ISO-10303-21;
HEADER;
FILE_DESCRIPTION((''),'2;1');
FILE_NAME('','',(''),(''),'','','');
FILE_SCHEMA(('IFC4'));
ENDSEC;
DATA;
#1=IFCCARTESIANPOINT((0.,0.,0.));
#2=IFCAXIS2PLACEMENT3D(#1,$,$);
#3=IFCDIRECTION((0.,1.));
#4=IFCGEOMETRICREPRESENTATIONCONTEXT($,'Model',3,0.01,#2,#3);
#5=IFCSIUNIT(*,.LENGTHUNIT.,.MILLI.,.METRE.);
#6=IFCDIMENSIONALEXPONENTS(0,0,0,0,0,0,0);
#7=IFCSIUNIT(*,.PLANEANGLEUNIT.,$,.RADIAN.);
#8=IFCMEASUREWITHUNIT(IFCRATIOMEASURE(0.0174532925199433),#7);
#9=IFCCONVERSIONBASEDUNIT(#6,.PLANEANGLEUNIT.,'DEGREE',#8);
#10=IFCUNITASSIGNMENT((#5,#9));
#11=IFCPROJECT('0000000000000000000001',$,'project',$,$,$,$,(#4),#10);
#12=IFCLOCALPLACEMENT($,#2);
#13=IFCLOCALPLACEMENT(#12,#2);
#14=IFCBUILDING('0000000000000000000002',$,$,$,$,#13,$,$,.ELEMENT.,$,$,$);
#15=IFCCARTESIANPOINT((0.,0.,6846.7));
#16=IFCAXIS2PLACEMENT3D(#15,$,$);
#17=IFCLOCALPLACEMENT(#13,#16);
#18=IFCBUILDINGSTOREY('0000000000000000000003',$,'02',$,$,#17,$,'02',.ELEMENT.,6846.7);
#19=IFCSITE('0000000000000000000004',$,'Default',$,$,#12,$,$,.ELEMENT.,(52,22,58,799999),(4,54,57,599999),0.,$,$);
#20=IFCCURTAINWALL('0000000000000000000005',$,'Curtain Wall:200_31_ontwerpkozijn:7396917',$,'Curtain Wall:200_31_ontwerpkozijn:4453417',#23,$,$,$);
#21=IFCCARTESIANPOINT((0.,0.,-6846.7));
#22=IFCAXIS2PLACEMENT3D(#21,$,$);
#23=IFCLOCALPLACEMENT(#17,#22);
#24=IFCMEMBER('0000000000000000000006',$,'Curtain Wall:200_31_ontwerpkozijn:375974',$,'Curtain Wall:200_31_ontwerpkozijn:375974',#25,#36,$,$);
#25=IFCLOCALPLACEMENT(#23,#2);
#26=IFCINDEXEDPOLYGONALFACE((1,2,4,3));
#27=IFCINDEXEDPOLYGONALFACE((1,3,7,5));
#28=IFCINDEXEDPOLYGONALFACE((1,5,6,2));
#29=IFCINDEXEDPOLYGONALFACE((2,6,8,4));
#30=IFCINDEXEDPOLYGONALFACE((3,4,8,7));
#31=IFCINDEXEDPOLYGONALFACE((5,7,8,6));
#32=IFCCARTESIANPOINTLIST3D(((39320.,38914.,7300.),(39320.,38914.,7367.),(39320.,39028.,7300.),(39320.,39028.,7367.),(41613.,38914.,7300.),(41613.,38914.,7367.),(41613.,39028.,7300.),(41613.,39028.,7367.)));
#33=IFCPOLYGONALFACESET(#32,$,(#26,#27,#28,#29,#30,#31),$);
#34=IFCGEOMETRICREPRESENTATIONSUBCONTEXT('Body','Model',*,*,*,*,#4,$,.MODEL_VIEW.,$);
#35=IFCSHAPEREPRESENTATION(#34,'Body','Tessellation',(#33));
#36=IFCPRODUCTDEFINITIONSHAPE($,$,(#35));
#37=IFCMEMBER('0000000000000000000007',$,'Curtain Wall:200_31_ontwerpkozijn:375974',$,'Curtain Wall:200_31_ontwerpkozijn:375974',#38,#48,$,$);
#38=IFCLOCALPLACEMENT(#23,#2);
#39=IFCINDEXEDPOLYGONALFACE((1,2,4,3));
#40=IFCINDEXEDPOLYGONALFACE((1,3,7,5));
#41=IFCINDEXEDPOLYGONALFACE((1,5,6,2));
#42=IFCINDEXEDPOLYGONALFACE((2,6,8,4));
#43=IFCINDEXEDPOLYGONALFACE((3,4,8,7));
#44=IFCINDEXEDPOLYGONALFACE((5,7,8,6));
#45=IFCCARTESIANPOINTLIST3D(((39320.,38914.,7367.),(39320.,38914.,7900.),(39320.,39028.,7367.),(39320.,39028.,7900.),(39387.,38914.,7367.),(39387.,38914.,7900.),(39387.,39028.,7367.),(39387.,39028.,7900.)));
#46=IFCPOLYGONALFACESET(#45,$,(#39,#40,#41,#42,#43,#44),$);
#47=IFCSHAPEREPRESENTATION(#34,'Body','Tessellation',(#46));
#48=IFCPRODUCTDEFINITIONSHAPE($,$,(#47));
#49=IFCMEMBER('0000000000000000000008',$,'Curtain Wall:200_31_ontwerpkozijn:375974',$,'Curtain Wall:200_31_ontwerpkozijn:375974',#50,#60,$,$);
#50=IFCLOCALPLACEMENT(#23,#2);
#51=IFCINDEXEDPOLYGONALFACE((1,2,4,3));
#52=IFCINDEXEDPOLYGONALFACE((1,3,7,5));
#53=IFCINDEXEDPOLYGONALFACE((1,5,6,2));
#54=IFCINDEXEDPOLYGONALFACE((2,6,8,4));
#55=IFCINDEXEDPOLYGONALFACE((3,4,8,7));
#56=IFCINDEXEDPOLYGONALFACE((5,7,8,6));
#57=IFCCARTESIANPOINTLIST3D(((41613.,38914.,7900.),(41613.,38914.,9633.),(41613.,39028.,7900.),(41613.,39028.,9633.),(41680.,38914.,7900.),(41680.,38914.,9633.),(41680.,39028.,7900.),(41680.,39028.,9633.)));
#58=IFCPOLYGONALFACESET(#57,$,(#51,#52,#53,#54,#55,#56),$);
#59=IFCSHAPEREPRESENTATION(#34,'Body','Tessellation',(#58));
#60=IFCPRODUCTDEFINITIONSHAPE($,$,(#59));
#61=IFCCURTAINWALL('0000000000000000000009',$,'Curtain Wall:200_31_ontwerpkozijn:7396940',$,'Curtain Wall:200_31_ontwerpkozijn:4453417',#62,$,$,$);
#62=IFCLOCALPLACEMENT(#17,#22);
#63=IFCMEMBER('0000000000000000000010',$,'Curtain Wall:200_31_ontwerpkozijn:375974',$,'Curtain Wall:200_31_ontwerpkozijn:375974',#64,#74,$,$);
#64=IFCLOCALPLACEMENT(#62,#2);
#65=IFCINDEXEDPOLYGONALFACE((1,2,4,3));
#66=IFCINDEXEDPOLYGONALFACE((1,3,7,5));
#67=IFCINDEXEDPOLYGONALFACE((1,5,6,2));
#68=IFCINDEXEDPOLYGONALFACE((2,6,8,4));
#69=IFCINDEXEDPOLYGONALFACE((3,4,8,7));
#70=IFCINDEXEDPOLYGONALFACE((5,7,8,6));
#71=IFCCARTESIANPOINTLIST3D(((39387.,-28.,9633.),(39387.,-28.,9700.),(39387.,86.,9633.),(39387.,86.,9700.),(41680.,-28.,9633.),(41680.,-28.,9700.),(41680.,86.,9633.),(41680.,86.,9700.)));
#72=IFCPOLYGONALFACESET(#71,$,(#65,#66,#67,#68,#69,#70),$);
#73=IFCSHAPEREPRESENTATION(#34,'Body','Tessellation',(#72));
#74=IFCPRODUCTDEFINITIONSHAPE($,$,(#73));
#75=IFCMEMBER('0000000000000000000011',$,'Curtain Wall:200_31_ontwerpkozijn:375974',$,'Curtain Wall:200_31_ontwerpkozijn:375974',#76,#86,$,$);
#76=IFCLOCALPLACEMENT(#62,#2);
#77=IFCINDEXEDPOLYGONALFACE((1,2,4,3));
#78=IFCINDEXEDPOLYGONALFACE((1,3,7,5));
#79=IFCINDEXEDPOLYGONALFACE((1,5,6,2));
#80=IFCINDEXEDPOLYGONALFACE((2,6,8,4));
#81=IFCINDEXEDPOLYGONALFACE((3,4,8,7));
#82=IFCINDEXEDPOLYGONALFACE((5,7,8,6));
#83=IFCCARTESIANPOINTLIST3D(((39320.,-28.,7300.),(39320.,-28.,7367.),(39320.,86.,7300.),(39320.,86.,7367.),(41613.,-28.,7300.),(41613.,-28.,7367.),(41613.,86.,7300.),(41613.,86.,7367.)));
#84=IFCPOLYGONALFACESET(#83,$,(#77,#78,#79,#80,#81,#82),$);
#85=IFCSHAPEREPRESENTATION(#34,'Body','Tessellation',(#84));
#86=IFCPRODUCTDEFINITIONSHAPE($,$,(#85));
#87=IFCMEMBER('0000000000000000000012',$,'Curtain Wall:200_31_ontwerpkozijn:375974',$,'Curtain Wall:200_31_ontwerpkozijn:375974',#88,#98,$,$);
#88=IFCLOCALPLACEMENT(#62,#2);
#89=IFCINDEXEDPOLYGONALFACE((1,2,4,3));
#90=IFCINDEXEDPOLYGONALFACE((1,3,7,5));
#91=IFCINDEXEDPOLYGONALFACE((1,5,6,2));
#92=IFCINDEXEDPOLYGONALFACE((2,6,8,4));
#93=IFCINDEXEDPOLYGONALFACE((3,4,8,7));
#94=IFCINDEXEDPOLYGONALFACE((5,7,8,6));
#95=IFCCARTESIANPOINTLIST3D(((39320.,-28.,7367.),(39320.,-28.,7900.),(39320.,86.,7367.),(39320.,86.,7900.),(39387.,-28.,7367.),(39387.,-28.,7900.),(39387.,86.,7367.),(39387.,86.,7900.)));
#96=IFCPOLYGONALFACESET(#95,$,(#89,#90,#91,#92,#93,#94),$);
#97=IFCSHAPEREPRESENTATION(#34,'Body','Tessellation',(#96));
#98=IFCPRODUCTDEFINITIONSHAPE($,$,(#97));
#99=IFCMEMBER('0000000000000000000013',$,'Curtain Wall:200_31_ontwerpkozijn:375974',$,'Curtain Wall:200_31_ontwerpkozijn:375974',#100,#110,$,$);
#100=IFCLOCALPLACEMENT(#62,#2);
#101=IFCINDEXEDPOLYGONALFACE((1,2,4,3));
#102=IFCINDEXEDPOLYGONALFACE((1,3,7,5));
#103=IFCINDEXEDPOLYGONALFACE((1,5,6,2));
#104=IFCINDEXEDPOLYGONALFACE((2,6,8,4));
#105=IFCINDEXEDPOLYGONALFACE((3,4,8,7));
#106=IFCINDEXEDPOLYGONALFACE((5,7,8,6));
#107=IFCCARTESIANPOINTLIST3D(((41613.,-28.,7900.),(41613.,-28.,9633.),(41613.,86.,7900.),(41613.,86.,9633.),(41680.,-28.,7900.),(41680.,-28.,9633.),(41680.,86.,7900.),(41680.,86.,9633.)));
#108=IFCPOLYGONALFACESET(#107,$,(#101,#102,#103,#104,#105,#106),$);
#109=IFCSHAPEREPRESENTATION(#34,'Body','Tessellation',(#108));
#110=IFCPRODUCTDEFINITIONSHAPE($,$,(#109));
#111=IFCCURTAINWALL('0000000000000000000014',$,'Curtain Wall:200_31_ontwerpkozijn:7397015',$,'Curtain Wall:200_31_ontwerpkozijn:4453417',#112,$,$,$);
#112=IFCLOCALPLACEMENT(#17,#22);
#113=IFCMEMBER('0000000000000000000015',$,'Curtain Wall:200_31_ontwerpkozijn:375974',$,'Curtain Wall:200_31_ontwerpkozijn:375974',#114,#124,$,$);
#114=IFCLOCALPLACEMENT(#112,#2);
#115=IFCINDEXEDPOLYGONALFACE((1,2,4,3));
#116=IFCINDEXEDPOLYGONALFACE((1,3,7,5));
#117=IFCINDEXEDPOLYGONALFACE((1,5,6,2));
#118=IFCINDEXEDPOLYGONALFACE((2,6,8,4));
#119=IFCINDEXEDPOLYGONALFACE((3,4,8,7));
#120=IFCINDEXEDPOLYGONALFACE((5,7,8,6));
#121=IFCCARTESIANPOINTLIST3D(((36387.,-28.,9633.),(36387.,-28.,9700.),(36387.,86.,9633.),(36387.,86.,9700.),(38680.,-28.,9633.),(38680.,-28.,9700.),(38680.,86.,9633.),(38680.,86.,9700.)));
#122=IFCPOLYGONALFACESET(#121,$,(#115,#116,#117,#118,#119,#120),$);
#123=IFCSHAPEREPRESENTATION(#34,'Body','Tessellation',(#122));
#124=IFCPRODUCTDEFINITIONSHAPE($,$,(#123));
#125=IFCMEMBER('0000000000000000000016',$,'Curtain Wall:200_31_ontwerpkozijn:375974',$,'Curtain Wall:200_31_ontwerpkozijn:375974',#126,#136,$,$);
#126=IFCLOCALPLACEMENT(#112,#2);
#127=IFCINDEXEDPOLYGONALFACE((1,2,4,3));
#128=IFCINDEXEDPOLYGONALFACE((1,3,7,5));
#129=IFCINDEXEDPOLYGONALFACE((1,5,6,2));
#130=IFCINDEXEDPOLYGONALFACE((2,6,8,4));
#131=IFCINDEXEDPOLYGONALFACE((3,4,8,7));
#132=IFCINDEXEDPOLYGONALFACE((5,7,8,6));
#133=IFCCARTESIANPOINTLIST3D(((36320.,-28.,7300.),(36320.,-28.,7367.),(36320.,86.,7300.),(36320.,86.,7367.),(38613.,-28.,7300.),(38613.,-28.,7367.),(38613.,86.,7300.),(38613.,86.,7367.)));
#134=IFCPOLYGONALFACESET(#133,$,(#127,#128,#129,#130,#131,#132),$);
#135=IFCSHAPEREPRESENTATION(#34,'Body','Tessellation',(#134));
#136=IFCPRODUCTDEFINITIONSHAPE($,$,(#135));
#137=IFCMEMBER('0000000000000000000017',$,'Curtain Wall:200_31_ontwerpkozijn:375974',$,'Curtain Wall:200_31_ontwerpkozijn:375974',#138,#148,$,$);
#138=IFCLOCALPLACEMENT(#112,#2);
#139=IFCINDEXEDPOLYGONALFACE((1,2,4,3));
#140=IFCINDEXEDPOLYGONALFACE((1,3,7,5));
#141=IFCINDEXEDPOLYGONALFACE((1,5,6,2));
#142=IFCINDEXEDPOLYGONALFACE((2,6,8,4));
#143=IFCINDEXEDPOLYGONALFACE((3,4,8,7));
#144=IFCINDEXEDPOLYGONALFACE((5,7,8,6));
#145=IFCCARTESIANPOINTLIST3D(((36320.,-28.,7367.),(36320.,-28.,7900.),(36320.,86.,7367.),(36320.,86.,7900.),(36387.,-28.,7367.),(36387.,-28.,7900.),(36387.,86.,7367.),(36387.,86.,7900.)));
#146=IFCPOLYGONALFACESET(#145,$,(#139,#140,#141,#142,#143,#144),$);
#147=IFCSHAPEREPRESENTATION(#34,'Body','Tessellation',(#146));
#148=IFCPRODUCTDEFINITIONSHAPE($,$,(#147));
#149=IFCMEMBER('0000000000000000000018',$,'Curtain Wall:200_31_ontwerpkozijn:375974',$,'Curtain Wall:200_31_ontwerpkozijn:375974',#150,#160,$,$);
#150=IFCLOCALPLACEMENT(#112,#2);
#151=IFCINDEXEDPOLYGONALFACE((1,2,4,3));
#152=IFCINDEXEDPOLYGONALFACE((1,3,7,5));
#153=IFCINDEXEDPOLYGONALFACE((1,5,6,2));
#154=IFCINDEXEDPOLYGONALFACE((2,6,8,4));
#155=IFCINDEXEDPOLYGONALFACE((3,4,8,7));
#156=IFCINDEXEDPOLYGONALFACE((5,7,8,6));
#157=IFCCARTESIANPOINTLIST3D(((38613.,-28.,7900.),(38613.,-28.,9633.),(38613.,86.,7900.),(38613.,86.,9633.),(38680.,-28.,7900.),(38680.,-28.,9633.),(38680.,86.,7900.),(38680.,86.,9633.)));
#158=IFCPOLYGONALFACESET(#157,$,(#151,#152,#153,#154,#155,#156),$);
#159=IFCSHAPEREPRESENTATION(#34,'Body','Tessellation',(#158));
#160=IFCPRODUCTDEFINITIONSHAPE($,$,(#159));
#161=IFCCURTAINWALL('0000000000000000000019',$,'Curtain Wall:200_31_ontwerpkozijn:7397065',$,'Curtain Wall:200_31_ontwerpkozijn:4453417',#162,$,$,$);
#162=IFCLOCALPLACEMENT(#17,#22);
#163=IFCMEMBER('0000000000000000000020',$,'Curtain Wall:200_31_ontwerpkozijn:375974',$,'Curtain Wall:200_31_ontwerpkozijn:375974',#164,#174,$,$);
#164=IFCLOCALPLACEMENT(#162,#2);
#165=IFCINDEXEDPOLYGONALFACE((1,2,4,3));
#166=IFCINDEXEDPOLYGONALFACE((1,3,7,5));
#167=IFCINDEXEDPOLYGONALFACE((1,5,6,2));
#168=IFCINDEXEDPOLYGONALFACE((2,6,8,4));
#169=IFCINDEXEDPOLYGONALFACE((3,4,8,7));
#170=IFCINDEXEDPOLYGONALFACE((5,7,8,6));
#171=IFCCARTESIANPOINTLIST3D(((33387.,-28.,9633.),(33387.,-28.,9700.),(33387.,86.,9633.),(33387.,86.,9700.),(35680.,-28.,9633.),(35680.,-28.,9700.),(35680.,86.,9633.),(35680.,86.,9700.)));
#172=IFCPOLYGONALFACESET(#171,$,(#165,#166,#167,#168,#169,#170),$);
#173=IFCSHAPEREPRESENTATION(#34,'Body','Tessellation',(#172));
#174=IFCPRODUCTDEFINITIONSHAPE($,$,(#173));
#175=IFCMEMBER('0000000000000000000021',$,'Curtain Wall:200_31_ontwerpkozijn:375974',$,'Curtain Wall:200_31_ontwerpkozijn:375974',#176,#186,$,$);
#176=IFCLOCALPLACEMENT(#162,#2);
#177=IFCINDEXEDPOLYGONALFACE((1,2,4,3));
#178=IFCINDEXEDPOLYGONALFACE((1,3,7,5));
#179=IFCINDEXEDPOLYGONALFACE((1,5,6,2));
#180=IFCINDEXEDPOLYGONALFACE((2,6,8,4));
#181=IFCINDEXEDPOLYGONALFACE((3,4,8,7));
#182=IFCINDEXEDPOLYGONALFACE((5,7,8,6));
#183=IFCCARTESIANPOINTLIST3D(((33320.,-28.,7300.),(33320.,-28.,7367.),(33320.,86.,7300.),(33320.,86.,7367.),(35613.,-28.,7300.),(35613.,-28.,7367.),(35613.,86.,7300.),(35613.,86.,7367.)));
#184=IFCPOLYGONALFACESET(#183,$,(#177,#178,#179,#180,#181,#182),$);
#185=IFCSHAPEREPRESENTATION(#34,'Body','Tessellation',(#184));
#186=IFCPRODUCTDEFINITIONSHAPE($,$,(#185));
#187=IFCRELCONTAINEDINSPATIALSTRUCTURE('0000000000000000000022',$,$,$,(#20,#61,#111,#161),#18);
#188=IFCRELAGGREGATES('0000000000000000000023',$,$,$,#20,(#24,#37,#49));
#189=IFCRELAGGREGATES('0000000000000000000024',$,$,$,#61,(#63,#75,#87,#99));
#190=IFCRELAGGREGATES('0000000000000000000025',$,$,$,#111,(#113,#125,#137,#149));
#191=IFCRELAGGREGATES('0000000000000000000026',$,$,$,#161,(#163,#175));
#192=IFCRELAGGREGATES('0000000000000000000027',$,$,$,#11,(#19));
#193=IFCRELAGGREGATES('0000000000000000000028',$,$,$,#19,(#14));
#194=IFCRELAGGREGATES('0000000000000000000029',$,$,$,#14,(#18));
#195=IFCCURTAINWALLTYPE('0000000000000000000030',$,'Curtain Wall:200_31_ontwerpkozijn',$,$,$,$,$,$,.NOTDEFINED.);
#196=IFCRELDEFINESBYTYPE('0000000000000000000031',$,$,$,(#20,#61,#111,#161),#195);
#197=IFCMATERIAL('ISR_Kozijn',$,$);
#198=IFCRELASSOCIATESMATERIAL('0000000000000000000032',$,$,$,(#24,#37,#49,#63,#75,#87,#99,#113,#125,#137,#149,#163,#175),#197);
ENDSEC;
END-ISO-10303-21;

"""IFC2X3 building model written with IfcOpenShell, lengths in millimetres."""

from ifc_helpers import new_model, entity, si_unit, converted_unit, direction, frame, frame_2d, origin, origin_2d_with_axis, place, context, subcontext, project, spatial, rectangle, extrude, material, type_object, element, aggregate, save


model = new_model("IFC2X3")

# Units and contexts
model_context = context("Model", 3, precision=0.01, world=origin(), true_north=direction((0.0, 1.0)))
body_context = subcontext(model_context, "Body", "Model", "MODEL_VIEW")
ifc_project = project(units=[si_unit("LENGTHUNIT", "METRE", prefix="MILLI"), converted_unit("PLANEANGLEUNIT", "DEGREE", entity("IfcRatioMeasure", 0.0174532925199433), si_unit("PLANEANGLEUNIT", "RADIAN"), dimensions=[0, 0, 0, 0, 0, 0, 0])], contexts=[model_context])

# Site, building, storey
site_placement = place(None, origin())
site = spatial("IfcSite", under=ifc_project, at=site_placement, Name="Default", CompositionType="ELEMENT", RefLatitude=(52, 22, 58, 799999), RefLongitude=(4, 54, 57, 599999), RefElevation=0.0)
building_placement = place(site_placement, origin())
building = spatial("IfcBuilding", under=site, at=building_placement, CompositionType="ELEMENT")
storey_placement = place(building_placement, frame((0.0, 0.0, 6846.7)))
storey = spatial("IfcBuildingStorey", under=building, at=storey_placement, Name="02", LongName="02", CompositionType="ELEMENT", Elevation=6846.7)

# Curtain walls, members
curtain_wall_type = type_object("IfcCurtainWallType", Name="Curtain Wall:200_31_ontwerpkozijn", PredefinedType="NOTDEFINED")
ifc_material = material(Name="ISR_Kozijn")
curtain_wall_1_placement = place(storey_placement, frame((0.0, 0.0, -6846.7)))
curtain_wall_1 = element("IfcCurtainWall", 1, at=curtain_wall_1_placement, inside=storey, type_object=curtain_wall_type, Name="Curtain Wall:200_31_ontwerpkozijn:7396917", ObjectType="Curtain Wall:200_31_ontwerpkozijn:4453417")
member_1_placement = place(curtain_wall_1_placement, origin())
member_1 = element("IfcMember", 2, at=member_1_placement, material=ifc_material, Name="Curtain Wall:200_31_ontwerpkozijn:375974", ObjectType="Curtain Wall:200_31_ontwerpkozijn:375974", context=body_context, shape_type="SweptSolid", body=[
    extrude(rectangle(XDim=67.0, YDim=114.0, at=frame_2d((0.0, 0.0), x_axis=(1.0, 0.0))), frame((41613.0, 38971.0, 7333.5), z_axis=(-1.0, 0.0, 0.0), x_axis=(0.0, 0.0, -1.0)), (0.0, 0.0, 1.0), 2293.0),
])
member_2_placement = place(curtain_wall_1_placement, origin())
member_2 = element("IfcMember", 3, at=member_2_placement, material=ifc_material, Name="Curtain Wall:200_31_ontwerpkozijn:375974", ObjectType="Curtain Wall:200_31_ontwerpkozijn:375974", context=body_context, shape_type="SweptSolid", body=[
    extrude(rectangle(XDim=67.0, YDim=114.0, at=frame_2d((0.0, 0.0), x_axis=(1.0, 0.0))), frame((39353.5, 38971.0, 7367.0), z_axis=(0.0, 0.0, 1.0), x_axis=(-1.0, 0.0, 0.0)), (0.0, 0.0, 1.0), 533.0),
])
member_3_placement = place(curtain_wall_1_placement, origin())
member_3 = element("IfcMember", 4, at=member_3_placement, material=ifc_material, Name="Curtain Wall:200_31_ontwerpkozijn:375974", ObjectType="Curtain Wall:200_31_ontwerpkozijn:375974", context=body_context, shape_type="SweptSolid", body=[
    extrude(rectangle(XDim=67.0, YDim=114.0, at=frame_2d((0.0, 0.0), x_axis=(1.0, 0.0))), frame((41646.5, 38971.0, 9633.0), z_axis=(0.0, 0.0, -1.0), x_axis=(-1.0, 0.0, 0.0)), (0.0, 0.0, 1.0), 1733.0),
])
aggregate(curtain_wall_1, [member_1, member_2, member_3])
curtain_wall_2_placement = place(storey_placement, frame((0.0, 0.0, -6846.7)))
curtain_wall_2 = element("IfcCurtainWall", 5, at=curtain_wall_2_placement, inside=storey, type_object=curtain_wall_type, Name="Curtain Wall:200_31_ontwerpkozijn:7396940", ObjectType="Curtain Wall:200_31_ontwerpkozijn:4453417")
member_4_placement = place(curtain_wall_2_placement, origin())
member_4 = element("IfcMember", 6, at=member_4_placement, material=ifc_material, Name="Curtain Wall:200_31_ontwerpkozijn:375974", ObjectType="Curtain Wall:200_31_ontwerpkozijn:375974", context=body_context, shape_type="SweptSolid", body=[
    extrude(rectangle(XDim=67.0, YDim=114.0, at=frame_2d((0.0, 0.0), x_axis=(1.0, 0.0))), frame((39387.0, 29.0, 9666.5), z_axis=(1.0, 0.0, 0.0), x_axis=(0.0, 0.0, -1.0)), (0.0, 0.0, 1.0), 2293.0),
])
member_5_placement = place(curtain_wall_2_placement, origin())
member_5 = element("IfcMember", 7, at=member_5_placement, material=ifc_material, Name="Curtain Wall:200_31_ontwerpkozijn:375974", ObjectType="Curtain Wall:200_31_ontwerpkozijn:375974", context=body_context, shape_type="SweptSolid", body=[
    extrude(rectangle(XDim=67.0, YDim=114.0, at=frame_2d((0.0, 0.0), x_axis=(1.0, 0.0))), frame((41613.0, 29.0, 7333.5), z_axis=(-1.0, 0.0, 0.0), x_axis=(0.0, 0.0, -1.0)), (0.0, 0.0, 1.0), 2293.0),
])
member_6_placement = place(curtain_wall_2_placement, origin())
member_6 = element("IfcMember", 8, at=member_6_placement, material=ifc_material, Name="Curtain Wall:200_31_ontwerpkozijn:375974", ObjectType="Curtain Wall:200_31_ontwerpkozijn:375974", context=body_context, shape_type="SweptSolid", body=[
    extrude(rectangle(XDim=67.0, YDim=114.0, at=origin_2d_with_axis()), frame((39353.5, 29.0, 7367.0), z_axis=(0.0, 0.0, 1.0), x_axis=(-1.0, 0.0, 0.0)), (0.0, 0.0, 1.0), 533.0),
])
member_7_placement = place(curtain_wall_2_placement, origin())
member_7 = element("IfcMember", 9, at=member_7_placement, material=ifc_material, Name="Curtain Wall:200_31_ontwerpkozijn:375974", ObjectType="Curtain Wall:200_31_ontwerpkozijn:375974", context=body_context, shape_type="SweptSolid", body=[
    extrude(rectangle(XDim=67.0, YDim=114.0, at=origin_2d_with_axis()), frame((41646.5, 29.0, 9633.0), z_axis=(0.0, 0.0, -1.0), x_axis=(-1.0, 0.0, 0.0)), (0.0, 0.0, 1.0), 1733.0),
])
aggregate(curtain_wall_2, [member_4, member_5, member_6, member_7])
curtain_wall_3_placement = place(storey_placement, frame((0.0, 0.0, -6846.7)))
curtain_wall_3 = element("IfcCurtainWall", 10, at=curtain_wall_3_placement, inside=storey, type_object=curtain_wall_type, Name="Curtain Wall:200_31_ontwerpkozijn:7397015", ObjectType="Curtain Wall:200_31_ontwerpkozijn:4453417")
member_8_placement = place(curtain_wall_3_placement, origin())
member_8 = element("IfcMember", 11, at=member_8_placement, material=ifc_material, Name="Curtain Wall:200_31_ontwerpkozijn:375974", ObjectType="Curtain Wall:200_31_ontwerpkozijn:375974", context=body_context, shape_type="SweptSolid", body=[
    extrude(rectangle(XDim=67.0, YDim=114.0, at=frame_2d((0.0, 0.0), x_axis=(1.0, 0.0))), frame((36387.0, 29.0, 9666.5), z_axis=(1.0, 0.0, 0.0), x_axis=(0.0, 0.0, -1.0)), (0.0, 0.0, 1.0), 2293.0),
])
member_9_placement = place(curtain_wall_3_placement, origin())
member_9 = element("IfcMember", 12, at=member_9_placement, material=ifc_material, Name="Curtain Wall:200_31_ontwerpkozijn:375974", ObjectType="Curtain Wall:200_31_ontwerpkozijn:375974", context=body_context, shape_type="SweptSolid", body=[
    extrude(rectangle(XDim=67.0, YDim=114.0, at=frame_2d((0.0, 0.0), x_axis=(1.0, 0.0))), frame((38613.0, 29.0, 7333.5), z_axis=(-1.0, 0.0, 0.0), x_axis=(0.0, 0.0, -1.0)), (0.0, 0.0, 1.0), 2293.0),
])
member_10_placement = place(curtain_wall_3_placement, origin())
member_10 = element("IfcMember", 13, at=member_10_placement, material=ifc_material, Name="Curtain Wall:200_31_ontwerpkozijn:375974", ObjectType="Curtain Wall:200_31_ontwerpkozijn:375974", context=body_context, shape_type="SweptSolid", body=[
    extrude(rectangle(XDim=67.0, YDim=114.0, at=origin_2d_with_axis()), frame((36353.5, 29.0, 7367.0), z_axis=(0.0, 0.0, 1.0), x_axis=(-1.0, 0.0, 0.0)), (0.0, 0.0, 1.0), 533.0),
])
member_11_placement = place(curtain_wall_3_placement, origin())
member_11 = element("IfcMember", 14, at=member_11_placement, material=ifc_material, Name="Curtain Wall:200_31_ontwerpkozijn:375974", ObjectType="Curtain Wall:200_31_ontwerpkozijn:375974", context=body_context, shape_type="SweptSolid", body=[
    extrude(rectangle(XDim=67.0, YDim=114.0, at=origin_2d_with_axis()), frame((38646.5, 29.0, 9633.0), z_axis=(0.0, 0.0, -1.0), x_axis=(-1.0, 0.0, 0.0)), (0.0, 0.0, 1.0), 1733.0),
])
aggregate(curtain_wall_3, [member_8, member_9, member_10, member_11])
curtain_wall_4_placement = place(storey_placement, frame((0.0, 0.0, -6846.7)))
curtain_wall_4 = element("IfcCurtainWall", 15, at=curtain_wall_4_placement, inside=storey, type_object=curtain_wall_type, Name="Curtain Wall:200_31_ontwerpkozijn:7397065", ObjectType="Curtain Wall:200_31_ontwerpkozijn:4453417")
member_12_placement = place(curtain_wall_4_placement, origin())
member_12 = element("IfcMember", 16, at=member_12_placement, material=ifc_material, Name="Curtain Wall:200_31_ontwerpkozijn:375974", ObjectType="Curtain Wall:200_31_ontwerpkozijn:375974", context=body_context, shape_type="SweptSolid", body=[
    extrude(rectangle(XDim=67.0, YDim=114.0, at=frame_2d((0.0, 0.0), x_axis=(1.0, 0.0))), frame((33387.0, 29.0, 9666.5), z_axis=(1.0, 0.0, 0.0), x_axis=(0.0, 0.0, -1.0)), (0.0, 0.0, 1.0), 2293.0),
])
member_13_placement = place(curtain_wall_4_placement, origin())
member_13 = element("IfcMember", 17, at=member_13_placement, material=ifc_material, Name="Curtain Wall:200_31_ontwerpkozijn:375974", ObjectType="Curtain Wall:200_31_ontwerpkozijn:375974", context=body_context, shape_type="SweptSolid", body=[
    extrude(rectangle(XDim=67.0, YDim=114.0, at=frame_2d((0.0, 0.0), x_axis=(1.0, 0.0))), frame((35613.0, 29.0, 7333.5), z_axis=(-1.0, 0.0, 0.0), x_axis=(0.0, 0.0, -1.0)), (0.0, 0.0, 1.0), 2293.0),
])
aggregate(curtain_wall_4, [member_12, member_13])

save(model, "model.ifc")
